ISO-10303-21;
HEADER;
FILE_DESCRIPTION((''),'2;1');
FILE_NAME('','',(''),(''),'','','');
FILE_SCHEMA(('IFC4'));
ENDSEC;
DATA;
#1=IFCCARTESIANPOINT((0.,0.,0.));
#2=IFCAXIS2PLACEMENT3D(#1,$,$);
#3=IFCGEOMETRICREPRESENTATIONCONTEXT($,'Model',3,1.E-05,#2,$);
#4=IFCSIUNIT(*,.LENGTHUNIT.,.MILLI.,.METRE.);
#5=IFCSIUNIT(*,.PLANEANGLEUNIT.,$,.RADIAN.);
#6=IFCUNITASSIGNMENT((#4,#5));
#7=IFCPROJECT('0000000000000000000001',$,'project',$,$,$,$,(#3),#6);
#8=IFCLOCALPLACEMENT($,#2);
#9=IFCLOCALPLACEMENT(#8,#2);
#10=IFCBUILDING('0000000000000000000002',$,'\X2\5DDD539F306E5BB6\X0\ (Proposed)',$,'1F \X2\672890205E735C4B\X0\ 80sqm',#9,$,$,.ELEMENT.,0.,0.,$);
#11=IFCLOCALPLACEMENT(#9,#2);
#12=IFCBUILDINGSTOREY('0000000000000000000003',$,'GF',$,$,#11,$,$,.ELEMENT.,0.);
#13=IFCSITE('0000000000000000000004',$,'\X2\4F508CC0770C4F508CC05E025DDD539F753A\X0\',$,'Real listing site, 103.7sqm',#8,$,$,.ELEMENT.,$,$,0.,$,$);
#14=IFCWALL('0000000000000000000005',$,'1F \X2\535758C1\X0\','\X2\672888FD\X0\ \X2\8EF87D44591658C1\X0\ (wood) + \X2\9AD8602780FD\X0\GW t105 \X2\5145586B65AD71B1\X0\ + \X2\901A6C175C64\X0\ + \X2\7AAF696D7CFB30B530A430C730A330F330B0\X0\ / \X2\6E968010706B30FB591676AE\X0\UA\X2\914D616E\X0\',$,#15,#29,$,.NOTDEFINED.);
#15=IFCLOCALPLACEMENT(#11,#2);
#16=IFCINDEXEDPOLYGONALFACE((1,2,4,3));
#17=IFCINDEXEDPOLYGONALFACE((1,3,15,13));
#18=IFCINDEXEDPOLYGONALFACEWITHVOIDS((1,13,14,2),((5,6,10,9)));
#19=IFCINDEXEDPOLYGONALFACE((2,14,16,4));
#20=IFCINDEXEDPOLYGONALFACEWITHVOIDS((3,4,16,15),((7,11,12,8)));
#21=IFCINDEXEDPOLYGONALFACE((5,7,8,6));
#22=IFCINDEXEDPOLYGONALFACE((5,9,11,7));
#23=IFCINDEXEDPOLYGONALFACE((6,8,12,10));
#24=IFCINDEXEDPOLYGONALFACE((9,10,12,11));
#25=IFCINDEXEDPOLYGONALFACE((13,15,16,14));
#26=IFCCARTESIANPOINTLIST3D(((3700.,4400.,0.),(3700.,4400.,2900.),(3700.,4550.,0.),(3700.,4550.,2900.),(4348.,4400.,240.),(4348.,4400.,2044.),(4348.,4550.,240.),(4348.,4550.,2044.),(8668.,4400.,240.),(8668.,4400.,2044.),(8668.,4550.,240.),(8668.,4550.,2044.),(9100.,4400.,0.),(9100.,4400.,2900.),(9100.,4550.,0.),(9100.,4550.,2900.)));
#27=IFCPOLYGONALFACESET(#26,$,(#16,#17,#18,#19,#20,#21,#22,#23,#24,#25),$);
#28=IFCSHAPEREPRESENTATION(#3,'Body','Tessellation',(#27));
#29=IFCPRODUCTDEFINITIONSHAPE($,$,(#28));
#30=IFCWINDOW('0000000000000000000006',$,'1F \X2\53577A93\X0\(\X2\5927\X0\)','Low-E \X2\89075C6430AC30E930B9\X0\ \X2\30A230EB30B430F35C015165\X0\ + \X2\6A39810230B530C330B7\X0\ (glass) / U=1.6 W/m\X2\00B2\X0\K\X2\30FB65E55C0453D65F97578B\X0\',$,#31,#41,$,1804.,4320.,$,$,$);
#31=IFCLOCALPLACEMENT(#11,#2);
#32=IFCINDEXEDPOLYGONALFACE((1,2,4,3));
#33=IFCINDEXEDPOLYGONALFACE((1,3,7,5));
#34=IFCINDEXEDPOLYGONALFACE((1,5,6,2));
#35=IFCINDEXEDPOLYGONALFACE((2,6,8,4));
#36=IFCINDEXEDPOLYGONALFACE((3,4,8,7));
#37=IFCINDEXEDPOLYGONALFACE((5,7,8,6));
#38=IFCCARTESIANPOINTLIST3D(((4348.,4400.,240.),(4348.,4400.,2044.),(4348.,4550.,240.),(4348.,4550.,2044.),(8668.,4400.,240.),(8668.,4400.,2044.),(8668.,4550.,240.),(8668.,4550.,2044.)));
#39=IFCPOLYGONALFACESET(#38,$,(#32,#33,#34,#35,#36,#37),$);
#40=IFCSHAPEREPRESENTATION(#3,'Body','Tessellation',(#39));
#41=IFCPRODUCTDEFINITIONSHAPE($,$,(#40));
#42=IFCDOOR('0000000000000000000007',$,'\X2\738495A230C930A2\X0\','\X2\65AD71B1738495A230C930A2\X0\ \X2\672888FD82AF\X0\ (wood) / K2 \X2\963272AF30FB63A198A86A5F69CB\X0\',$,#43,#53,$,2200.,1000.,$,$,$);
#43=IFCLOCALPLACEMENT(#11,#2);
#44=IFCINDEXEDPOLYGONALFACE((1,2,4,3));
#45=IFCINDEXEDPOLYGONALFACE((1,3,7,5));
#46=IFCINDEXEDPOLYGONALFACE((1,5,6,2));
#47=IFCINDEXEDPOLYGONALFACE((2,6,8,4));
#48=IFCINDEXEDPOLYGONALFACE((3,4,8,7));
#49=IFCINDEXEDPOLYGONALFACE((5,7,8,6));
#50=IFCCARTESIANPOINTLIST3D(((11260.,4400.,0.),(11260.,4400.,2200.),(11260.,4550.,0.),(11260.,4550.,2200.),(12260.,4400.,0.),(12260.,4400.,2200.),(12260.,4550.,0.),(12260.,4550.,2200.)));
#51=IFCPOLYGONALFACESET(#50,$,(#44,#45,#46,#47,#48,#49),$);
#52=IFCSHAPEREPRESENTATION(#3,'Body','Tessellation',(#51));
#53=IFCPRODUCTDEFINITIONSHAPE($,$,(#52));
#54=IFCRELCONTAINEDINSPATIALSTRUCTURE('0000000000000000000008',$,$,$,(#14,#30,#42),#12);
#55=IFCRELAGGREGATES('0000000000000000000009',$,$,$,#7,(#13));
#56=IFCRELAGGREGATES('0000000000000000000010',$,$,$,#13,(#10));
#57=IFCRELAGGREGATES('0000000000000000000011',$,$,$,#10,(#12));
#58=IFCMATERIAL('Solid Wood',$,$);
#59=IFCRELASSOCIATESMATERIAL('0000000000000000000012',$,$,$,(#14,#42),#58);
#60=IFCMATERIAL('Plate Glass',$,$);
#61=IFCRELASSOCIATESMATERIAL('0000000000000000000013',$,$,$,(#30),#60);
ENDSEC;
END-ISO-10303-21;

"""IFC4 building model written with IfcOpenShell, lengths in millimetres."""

from ifc_helpers import new_model, si_unit, frame, frame_2d, origin, place, context, project, spatial, rectangle, extrude, material, element, fill, save


model = new_model("IFC4")

# Units and contexts
model_context = context("Model", 3, precision=1e-05, world=origin())
ifc_project = project(units=[si_unit("LENGTHUNIT", "METRE", prefix="MILLI"), si_unit("PLANEANGLEUNIT", "RADIAN")], contexts=[model_context])

# Site, building, storey
site_placement = place(None, origin())
site = spatial("IfcSite", under=ifc_project, at=site_placement, Name="佐賀県佐賀市川原町", ObjectType="Real listing site, 103.7sqm", CompositionType="ELEMENT", RefElevation=0.0)
building_placement = place(site_placement, origin())
building = spatial("IfcBuilding", under=site, at=building_placement, Name="川原の家 (Proposed)", ObjectType="1F 木造平屋 80sqm", CompositionType="ELEMENT", ElevationOfRefHeight=0.0, ElevationOfTerrain=0.0)
storey_placement = place(building_placement, origin())
storey = spatial("IfcBuildingStorey", under=building, at=storey_placement, Name="GF", CompositionType="ELEMENT", Elevation=0.0)

# Shared definitions
ifc_material_1 = material(Name="Solid Wood")

# Wall, openings, window, door
wall_1_placement = place(storey_placement, frame((1850.0, 2200.0, 0.0)))
wall_1 = element("IfcWall", 1, at=wall_1_placement, inside=storey, material=ifc_material_1, Name="1F 南壁", Description="木製 軸組外壁 (wood) + 高性能GW t105 充填断熱 + 通気層 + 窯業系サイディング / 準耐火・外皮UA配慮", PredefinedType="NOTDEFINED", context=model_context, shape_type="SweptSolid", body=[
    extrude(rectangle(XDim=5400.0, YDim=150.0, at=frame_2d((2700.0, 75.0))), frame((1850.0, 2200.0, 0.0)), (0.0, 0.0, 1.0), 2900.0),
])
opening_1_placement = place(storey_placement, frame((2174.0, 2200.0, 120.0)))
opening_1 = element("IfcOpeningElement", 2, at=opening_1_placement, cuts=wall_1, PredefinedType="NOTDEFINED", context=model_context, shape_type="SweptSolid", body=[
    extrude(rectangle(XDim=4320.0, YDim=150.0, at=frame_2d((2160.0, 75.0))), frame((2174.0, 2200.0, 120.0)), (0.0, 0.0, 1.0), 1804.0),
])
opening_2_placement = place(storey_placement, frame((5630.0, 2200.0, 0.0)))
opening_2 = element("IfcOpeningElement", 3, at=opening_2_placement, cuts=wall_1, PredefinedType="NOTDEFINED", context=model_context, shape_type="SweptSolid", body=[
    extrude(rectangle(XDim=1000.0, YDim=150.0, at=frame_2d((500.0, 75.0))), frame((5630.0, 2200.0, 0.0)), (0.0, 0.0, 1.0), 2200.0),
])
ifc_material_2 = material(Name="Plate Glass")
window_1_placement = place(storey_placement, frame((2174.0, 2200.0, 120.0)))
window_1 = element("IfcWindow", 4, at=window_1_placement, inside=storey, material=ifc_material_2, Name="1F 南窓(大)", Description="Low-E 複層ガラス アルゴン封入 + 樹脂サッシ (glass) / U=1.6 W/m²K・日射取得型", OverallHeight=1804.0, OverallWidth=4320.0, context=model_context, shape_type="SweptSolid", body=[
    extrude(rectangle(XDim=4320.0, YDim=150.0, at=frame_2d((2160.0, 75.0))), frame((2174.0, 2200.0, 120.0)), (0.0, 0.0, 1.0), 1804.0),
])
fill(opening_1, window_1)
door_placement = place(storey_placement, frame((5630.0, 2200.0, 0.0)))
door = element("IfcDoor", 5, at=door_placement, inside=storey, material=ifc_material_1, Name="玄関ドア", Description="断熱玄関ドア 木製芯 (wood) / K2 防犯・採風機構", OverallHeight=2200.0, OverallWidth=1000.0, context=model_context, shape_type="SweptSolid", body=[
    extrude(rectangle(XDim=1000.0, YDim=150.0, at=frame_2d((500.0, 75.0))), frame((5630.0, 2200.0, 0.0)), (0.0, 0.0, 1.0), 2200.0),
])
fill(opening_2, door)

save(model, "model.ifc")
